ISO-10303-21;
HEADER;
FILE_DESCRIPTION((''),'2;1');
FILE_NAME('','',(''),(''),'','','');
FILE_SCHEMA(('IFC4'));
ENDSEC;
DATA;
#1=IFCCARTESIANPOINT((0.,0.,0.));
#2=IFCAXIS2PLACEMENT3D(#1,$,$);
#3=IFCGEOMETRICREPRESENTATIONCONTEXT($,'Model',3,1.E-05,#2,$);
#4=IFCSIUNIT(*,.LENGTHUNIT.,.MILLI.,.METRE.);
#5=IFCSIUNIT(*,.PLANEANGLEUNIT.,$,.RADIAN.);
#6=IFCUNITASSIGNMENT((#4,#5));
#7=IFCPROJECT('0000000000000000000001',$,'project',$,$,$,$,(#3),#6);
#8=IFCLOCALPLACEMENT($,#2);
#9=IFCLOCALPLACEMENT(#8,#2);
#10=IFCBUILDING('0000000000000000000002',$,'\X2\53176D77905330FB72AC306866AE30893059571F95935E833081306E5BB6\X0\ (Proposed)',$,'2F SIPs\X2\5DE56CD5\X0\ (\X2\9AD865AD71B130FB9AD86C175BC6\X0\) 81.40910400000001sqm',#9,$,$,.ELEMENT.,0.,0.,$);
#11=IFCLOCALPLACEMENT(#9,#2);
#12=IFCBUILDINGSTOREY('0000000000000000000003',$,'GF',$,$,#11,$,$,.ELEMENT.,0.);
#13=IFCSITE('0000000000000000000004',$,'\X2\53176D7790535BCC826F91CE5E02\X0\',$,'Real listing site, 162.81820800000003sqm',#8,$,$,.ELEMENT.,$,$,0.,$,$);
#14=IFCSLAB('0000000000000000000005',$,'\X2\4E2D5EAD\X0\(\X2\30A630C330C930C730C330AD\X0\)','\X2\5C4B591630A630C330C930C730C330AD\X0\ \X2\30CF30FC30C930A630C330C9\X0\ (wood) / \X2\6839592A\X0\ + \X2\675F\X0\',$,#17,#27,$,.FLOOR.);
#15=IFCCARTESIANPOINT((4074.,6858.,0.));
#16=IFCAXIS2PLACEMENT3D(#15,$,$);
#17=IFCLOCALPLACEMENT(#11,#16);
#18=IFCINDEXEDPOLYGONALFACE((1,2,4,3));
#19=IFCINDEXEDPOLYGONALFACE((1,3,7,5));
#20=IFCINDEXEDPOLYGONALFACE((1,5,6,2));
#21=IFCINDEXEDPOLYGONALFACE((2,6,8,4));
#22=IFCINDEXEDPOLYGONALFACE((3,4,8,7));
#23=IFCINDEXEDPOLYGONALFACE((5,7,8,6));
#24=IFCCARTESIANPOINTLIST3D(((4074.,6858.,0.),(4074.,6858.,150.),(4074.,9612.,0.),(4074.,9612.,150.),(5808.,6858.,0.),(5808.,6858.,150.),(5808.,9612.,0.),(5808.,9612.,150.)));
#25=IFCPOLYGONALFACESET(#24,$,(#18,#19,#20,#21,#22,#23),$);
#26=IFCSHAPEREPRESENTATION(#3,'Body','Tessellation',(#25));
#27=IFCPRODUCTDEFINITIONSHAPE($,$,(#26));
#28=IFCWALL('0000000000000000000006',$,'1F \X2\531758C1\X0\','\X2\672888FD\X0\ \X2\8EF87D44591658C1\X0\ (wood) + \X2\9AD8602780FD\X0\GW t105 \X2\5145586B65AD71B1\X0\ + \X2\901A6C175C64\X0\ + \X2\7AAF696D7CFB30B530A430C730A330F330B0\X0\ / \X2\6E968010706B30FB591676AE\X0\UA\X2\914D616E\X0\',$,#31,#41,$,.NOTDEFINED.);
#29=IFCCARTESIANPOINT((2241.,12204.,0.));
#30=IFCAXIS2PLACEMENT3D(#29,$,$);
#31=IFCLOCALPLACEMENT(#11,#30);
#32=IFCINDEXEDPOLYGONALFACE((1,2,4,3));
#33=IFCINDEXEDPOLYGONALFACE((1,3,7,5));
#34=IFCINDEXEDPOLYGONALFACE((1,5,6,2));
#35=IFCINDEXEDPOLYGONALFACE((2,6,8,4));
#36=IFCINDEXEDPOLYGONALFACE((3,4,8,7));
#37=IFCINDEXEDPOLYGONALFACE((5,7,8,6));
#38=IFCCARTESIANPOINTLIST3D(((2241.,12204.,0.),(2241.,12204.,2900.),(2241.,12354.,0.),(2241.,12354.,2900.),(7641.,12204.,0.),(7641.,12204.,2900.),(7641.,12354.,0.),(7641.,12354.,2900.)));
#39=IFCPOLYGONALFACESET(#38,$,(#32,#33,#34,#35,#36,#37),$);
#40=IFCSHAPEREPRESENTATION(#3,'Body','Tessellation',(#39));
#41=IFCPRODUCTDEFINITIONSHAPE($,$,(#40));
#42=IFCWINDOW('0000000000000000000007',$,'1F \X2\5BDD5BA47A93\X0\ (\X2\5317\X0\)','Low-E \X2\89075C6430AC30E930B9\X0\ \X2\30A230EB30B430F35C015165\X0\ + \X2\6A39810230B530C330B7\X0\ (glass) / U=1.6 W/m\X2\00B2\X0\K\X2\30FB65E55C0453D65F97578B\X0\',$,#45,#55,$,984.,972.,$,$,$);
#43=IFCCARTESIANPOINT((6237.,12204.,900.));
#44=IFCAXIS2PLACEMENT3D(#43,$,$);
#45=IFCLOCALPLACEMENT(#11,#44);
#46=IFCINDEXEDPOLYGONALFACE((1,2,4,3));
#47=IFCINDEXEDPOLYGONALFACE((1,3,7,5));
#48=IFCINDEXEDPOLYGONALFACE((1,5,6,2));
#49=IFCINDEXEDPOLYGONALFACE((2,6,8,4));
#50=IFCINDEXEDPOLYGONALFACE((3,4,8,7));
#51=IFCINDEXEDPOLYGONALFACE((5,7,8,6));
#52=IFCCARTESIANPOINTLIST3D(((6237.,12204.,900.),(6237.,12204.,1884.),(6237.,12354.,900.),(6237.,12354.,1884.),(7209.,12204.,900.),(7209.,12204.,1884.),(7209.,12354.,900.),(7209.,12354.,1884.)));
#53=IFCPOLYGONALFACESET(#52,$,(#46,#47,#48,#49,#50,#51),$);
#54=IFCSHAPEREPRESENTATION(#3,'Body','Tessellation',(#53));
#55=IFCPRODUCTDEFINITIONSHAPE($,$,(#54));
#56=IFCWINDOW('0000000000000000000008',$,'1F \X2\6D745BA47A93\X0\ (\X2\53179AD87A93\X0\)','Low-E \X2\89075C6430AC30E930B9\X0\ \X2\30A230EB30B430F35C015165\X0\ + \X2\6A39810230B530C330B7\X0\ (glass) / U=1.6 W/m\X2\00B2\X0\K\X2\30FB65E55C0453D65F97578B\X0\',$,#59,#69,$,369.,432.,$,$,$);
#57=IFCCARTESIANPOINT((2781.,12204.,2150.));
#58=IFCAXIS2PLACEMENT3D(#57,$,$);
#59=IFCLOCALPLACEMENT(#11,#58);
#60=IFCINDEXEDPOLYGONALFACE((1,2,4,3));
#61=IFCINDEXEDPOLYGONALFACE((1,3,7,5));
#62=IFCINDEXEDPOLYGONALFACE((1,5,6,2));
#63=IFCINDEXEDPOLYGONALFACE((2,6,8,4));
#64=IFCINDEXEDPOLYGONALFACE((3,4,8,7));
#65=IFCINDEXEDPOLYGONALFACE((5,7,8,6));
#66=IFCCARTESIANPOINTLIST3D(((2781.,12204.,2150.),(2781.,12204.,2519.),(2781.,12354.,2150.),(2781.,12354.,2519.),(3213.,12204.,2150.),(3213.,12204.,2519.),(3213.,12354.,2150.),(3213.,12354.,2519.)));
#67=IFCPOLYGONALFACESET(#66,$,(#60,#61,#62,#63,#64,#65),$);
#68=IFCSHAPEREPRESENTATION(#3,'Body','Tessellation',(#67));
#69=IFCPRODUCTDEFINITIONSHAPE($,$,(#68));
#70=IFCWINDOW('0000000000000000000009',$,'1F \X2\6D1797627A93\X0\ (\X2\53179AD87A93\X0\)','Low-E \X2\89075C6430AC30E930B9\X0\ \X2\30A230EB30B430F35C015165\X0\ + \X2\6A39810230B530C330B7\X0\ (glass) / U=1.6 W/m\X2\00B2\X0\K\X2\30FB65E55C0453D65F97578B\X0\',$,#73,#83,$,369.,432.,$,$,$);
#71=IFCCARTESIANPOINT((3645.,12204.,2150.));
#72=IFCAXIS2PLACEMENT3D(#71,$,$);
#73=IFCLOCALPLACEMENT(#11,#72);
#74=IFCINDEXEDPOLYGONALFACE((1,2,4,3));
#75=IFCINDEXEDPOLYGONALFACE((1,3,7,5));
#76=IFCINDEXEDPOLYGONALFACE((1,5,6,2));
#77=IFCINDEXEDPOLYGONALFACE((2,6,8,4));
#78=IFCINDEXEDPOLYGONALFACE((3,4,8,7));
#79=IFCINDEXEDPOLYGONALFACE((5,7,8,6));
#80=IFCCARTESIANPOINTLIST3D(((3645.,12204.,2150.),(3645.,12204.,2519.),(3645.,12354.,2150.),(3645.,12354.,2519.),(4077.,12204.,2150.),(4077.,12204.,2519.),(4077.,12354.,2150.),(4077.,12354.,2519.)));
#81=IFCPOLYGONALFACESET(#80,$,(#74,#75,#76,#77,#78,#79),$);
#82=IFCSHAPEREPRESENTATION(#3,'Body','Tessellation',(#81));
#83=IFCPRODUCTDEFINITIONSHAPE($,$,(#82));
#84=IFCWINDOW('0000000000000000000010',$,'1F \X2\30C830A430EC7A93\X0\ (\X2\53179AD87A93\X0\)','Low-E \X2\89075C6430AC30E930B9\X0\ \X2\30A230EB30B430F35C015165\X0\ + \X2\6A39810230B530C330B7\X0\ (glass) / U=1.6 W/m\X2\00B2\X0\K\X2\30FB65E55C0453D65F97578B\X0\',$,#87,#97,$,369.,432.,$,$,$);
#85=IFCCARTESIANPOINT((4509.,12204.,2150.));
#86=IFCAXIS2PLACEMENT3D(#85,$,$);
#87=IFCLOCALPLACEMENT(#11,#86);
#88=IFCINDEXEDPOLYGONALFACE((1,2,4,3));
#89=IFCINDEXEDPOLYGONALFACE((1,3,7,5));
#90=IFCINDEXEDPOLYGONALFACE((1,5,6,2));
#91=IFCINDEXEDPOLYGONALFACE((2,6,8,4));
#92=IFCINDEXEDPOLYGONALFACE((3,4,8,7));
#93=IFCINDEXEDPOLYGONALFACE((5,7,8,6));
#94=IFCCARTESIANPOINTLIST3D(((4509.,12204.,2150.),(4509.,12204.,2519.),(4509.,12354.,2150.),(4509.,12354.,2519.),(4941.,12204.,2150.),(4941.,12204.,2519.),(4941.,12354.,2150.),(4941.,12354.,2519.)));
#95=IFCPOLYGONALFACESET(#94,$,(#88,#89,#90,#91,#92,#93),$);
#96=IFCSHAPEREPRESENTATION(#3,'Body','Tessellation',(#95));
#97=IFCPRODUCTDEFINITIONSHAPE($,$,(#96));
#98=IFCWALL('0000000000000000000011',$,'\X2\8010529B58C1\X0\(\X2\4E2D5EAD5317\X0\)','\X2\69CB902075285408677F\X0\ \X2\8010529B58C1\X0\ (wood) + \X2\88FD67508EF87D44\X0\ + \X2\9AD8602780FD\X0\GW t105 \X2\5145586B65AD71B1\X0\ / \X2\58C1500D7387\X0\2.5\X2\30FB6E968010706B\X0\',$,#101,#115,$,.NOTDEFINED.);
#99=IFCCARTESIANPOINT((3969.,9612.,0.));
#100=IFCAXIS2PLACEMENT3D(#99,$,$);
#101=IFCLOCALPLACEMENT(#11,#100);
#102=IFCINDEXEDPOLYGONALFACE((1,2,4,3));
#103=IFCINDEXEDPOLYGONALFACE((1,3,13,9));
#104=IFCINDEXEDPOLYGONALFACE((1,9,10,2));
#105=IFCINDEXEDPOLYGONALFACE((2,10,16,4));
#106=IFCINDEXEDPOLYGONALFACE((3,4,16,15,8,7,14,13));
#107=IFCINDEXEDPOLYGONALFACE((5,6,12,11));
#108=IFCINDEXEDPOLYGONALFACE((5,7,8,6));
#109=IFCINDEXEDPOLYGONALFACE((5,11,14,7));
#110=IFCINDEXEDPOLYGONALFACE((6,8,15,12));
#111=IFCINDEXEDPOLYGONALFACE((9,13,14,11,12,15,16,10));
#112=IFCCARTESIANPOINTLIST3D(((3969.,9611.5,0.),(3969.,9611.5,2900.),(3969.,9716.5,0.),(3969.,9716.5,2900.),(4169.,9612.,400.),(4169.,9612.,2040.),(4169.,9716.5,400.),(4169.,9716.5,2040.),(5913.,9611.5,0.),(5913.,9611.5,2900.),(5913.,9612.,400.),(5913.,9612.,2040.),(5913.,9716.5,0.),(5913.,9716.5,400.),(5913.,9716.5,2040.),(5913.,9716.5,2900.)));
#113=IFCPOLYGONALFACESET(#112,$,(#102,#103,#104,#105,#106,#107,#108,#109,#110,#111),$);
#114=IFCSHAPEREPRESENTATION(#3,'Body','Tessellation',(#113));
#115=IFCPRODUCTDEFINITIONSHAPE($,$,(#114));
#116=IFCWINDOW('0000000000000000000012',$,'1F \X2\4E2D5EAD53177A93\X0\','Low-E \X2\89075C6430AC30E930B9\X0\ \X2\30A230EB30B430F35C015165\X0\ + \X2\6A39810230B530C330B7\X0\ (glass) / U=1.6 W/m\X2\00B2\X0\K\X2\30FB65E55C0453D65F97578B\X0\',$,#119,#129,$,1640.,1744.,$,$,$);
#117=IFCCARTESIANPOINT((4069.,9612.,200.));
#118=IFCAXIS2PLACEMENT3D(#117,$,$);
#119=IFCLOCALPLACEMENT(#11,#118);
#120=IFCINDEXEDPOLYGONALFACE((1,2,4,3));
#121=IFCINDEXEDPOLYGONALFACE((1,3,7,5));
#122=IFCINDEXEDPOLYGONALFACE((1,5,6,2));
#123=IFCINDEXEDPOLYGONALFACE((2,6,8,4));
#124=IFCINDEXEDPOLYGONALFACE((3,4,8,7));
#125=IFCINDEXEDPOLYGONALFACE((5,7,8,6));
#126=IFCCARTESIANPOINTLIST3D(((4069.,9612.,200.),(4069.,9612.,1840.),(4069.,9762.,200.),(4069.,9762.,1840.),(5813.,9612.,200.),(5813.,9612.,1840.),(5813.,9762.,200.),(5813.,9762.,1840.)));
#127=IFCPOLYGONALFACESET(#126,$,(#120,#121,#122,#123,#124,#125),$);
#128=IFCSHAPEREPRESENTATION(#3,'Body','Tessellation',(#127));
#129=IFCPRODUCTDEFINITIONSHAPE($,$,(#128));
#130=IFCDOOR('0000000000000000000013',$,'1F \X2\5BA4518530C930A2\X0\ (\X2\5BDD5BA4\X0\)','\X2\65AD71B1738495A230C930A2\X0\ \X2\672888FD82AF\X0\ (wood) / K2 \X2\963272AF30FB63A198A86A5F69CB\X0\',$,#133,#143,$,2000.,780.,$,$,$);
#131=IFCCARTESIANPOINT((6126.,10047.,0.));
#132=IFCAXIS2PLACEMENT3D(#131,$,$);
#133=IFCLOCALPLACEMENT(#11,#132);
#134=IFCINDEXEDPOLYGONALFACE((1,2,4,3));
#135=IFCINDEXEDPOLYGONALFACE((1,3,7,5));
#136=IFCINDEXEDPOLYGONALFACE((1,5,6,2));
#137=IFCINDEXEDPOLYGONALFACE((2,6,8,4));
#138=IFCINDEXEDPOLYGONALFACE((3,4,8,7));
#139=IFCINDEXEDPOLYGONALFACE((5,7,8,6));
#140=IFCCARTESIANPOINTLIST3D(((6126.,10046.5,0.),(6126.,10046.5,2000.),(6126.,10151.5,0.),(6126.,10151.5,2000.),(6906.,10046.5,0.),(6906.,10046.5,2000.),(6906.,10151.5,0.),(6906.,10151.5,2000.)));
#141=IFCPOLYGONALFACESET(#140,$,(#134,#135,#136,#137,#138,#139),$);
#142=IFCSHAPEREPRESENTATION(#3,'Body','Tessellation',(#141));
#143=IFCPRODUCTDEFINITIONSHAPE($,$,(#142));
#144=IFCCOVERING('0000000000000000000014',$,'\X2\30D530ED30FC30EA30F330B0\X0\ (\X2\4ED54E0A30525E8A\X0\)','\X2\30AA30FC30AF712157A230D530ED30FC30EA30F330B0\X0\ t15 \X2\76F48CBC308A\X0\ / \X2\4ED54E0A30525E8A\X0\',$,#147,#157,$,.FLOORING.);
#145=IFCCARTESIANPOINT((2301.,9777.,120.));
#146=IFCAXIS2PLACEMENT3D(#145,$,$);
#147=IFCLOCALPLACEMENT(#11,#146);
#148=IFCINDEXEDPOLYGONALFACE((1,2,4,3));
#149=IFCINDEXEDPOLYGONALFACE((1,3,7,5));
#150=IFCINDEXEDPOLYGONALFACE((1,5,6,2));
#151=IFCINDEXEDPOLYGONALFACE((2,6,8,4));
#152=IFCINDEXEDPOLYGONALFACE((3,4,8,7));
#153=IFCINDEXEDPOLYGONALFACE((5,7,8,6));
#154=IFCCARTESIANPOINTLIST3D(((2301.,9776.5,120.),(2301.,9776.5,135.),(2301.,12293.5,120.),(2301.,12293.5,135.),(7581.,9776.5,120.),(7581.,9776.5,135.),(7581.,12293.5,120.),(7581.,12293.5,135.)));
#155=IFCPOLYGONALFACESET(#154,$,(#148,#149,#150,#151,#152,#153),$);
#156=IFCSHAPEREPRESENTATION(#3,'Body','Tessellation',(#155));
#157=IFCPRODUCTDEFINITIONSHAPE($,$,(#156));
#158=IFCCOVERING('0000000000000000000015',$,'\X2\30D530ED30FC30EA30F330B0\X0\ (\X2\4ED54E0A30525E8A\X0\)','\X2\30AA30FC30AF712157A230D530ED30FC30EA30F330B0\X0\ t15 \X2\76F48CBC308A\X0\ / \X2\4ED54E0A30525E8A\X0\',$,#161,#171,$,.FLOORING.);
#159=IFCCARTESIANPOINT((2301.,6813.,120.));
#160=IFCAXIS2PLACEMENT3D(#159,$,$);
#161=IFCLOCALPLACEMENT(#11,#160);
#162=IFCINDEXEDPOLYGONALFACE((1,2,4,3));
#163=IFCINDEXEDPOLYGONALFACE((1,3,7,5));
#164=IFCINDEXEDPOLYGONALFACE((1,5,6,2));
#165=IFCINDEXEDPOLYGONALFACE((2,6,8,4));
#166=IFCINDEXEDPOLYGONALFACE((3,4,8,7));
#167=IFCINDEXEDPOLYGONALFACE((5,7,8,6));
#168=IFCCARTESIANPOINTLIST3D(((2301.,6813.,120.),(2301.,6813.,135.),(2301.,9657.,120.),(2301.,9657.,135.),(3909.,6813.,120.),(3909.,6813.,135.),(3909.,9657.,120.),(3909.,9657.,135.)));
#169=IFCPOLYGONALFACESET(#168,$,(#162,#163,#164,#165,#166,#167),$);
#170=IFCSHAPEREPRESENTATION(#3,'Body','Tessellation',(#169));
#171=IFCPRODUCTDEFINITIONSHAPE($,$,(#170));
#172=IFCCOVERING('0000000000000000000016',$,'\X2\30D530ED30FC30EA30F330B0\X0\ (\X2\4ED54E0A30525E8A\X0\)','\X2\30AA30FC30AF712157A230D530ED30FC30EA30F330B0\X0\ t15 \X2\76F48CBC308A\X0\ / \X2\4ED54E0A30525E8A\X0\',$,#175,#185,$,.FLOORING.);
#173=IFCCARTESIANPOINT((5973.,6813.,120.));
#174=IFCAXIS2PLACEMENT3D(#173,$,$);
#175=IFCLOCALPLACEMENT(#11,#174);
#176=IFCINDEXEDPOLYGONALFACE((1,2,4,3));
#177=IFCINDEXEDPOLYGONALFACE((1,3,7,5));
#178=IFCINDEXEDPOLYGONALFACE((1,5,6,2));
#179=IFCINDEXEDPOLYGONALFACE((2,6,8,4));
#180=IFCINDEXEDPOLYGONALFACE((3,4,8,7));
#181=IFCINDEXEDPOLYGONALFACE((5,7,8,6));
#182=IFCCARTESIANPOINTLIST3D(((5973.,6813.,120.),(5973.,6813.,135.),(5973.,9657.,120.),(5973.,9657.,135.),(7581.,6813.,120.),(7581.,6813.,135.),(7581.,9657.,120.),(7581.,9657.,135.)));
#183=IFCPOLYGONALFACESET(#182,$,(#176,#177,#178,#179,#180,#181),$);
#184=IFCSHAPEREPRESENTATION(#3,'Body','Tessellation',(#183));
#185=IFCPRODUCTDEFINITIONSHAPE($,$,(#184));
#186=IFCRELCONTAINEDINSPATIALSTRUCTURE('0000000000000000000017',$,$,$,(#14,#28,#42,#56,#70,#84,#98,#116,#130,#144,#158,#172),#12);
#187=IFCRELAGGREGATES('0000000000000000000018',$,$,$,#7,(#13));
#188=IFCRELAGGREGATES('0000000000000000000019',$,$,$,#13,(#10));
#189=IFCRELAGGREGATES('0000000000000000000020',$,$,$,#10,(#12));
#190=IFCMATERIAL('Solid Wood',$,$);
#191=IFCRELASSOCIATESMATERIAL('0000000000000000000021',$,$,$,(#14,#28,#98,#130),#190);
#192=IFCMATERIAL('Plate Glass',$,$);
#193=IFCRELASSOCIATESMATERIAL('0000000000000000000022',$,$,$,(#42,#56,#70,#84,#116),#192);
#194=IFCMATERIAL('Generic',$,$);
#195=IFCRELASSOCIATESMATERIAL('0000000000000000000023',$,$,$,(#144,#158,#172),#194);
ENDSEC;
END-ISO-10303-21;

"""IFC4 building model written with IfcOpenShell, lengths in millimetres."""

from ifc_helpers import new_model, si_unit, frame, frame_2d, origin, place, context, project, spatial, rectangle, extrude, material, element, fill, save


model = new_model("IFC4")

# Units and contexts
model_context = context("Model", 3, precision=1e-05, world=origin())
ifc_project = project(units=[si_unit("LENGTHUNIT", "METRE", prefix="MILLI"), si_unit("PLANEANGLEUNIT", "RADIAN")], contexts=[model_context])

# Site, building, storey
site_placement = place(None, origin())
site = spatial("IfcSite", under=ifc_project, at=site_placement, Name="北海道富良野市", ObjectType="Real listing site, 162.81820800000003sqm", CompositionType="ELEMENT", RefElevation=0.0)
building_placement = place(site_placement, origin())
building = spatial("IfcBuilding", under=site, at=building_placement, Name="北海道・犬と暮らす土間広めの家 (Proposed)", ObjectType="2F SIPs工法 (高断熱・高気密) 81.40910400000001sqm", CompositionType="ELEMENT", ElevationOfRefHeight=0.0, ElevationOfTerrain=0.0)
storey_placement = place(building_placement, origin())
storey = spatial("IfcBuildingStorey", under=building, at=storey_placement, Name="GF", CompositionType="ELEMENT", Elevation=0.0)

# Slab
ifc_material_1 = material(Name="Solid Wood")
slab_1_placement = place(storey_placement, frame((4074.0, 6858.0, 0.0)))
element("IfcSlab", 1, at=slab_1_placement, inside=storey, material=ifc_material_1, Name="中庭(ウッドデッキ)", Description="屋外ウッドデッキ ハードウッド (wood) / 根太 + 束", PredefinedType="FLOOR", context=model_context, shape_type="SweptSolid", body=[
    extrude(rectangle(XDim=1734.0, YDim=2754.0, at=frame_2d((867.0, 1377.0))), frame((4074.0, 6858.0, 0.0)), (0.0, 0.0, 1.0), 150.0),
])

# Wall, openings, windows
wall_1_placement = place(storey_placement, frame((2241.0, 12204.0, 0.0)))
wall_1 = element("IfcWall", 2, at=wall_1_placement, inside=storey, material=ifc_material_1, Name="1F 北壁", Description="木製 軸組外壁 (wood) + 高性能GW t105 充填断熱 + 通気層 + 窯業系サイディング / 準耐火・外皮UA配慮", PredefinedType="NOTDEFINED", context=model_context, shape_type="SweptSolid", body=[
    extrude(rectangle(XDim=5400.0, YDim=150.0, at=frame_2d((2700.0, 75.0))), frame((2241.0, 12204.0, 0.0)), (0.0, 0.0, 1.0), 2900.0),
])
opening_1_placement = place(storey_placement, frame((6237.0, 12204.0, 900.0)))
opening_1 = element("IfcOpeningElement", 3, at=opening_1_placement, cuts=wall_1, PredefinedType="NOTDEFINED", context=model_context, shape_type="SweptSolid", body=[
    extrude(rectangle(XDim=972.0, YDim=150.0, at=frame_2d((486.0, 75.0))), frame((6237.0, 12204.0, 900.0)), (0.0, 0.0, 1.0), 984.0),
])
opening_2_placement = place(storey_placement, frame((2781.0, 12204.0, 2150.0)))
opening_2 = element("IfcOpeningElement", 4, at=opening_2_placement, cuts=wall_1, PredefinedType="NOTDEFINED", context=model_context, shape_type="SweptSolid", body=[
    extrude(rectangle(XDim=432.0, YDim=150.0, at=frame_2d((216.0, 75.0))), frame((2781.0, 12204.0, 2150.0)), (0.0, 0.0, 1.0), 369.0),
])
opening_3_placement = place(storey_placement, frame((3645.0, 12204.0, 2150.0)))
opening_3 = element("IfcOpeningElement", 5, at=opening_3_placement, cuts=wall_1, PredefinedType="NOTDEFINED", context=model_context, shape_type="SweptSolid", body=[
    extrude(rectangle(XDim=432.0, YDim=150.0, at=frame_2d((216.0, 75.0))), frame((3645.0, 12204.0, 2150.0)), (0.0, 0.0, 1.0), 369.0),
])
opening_4_placement = place(storey_placement, frame((4509.0, 12204.0, 2150.0)))
opening_4 = element("IfcOpeningElement", 6, at=opening_4_placement, cuts=wall_1, PredefinedType="NOTDEFINED", context=model_context, shape_type="SweptSolid", body=[
    extrude(rectangle(XDim=432.0, YDim=150.0, at=frame_2d((216.0, 75.0))), frame((4509.0, 12204.0, 2150.0)), (0.0, 0.0, 1.0), 369.0),
])
ifc_material_2 = material(Name="Plate Glass")
window_1_placement = place(storey_placement, frame((6237.0, 12204.0, 900.0)))
window_1 = element("IfcWindow", 7, at=window_1_placement, inside=storey, material=ifc_material_2, Name="1F 寝室窓 (北)", Description="Low-E 複層ガラス アルゴン封入 + 樹脂サッシ (glass) / U=1.6 W/m²K・日射取得型", OverallHeight=984.0, OverallWidth=972.0, context=model_context, shape_type="SweptSolid", body=[
    extrude(rectangle(XDim=972.0, YDim=150.0, at=frame_2d((486.0, 75.0))), frame((6237.0, 12204.0, 900.0)), (0.0, 0.0, 1.0), 984.0),
])
fill(opening_1, window_1)
window_2_placement = place(storey_placement, frame((2781.0, 12204.0, 2150.0)))
window_2 = element("IfcWindow", 8, at=window_2_placement, inside=storey, material=ifc_material_2, Name="1F 浴室窓 (北高窓)", Description="Low-E 複層ガラス アルゴン封入 + 樹脂サッシ (glass) / U=1.6 W/m²K・日射取得型", OverallHeight=369.0, OverallWidth=432.0, context=model_context, shape_type="SweptSolid", body=[
    extrude(rectangle(XDim=432.0, YDim=150.0, at=frame_2d((216.0, 75.0))), frame((2781.0, 12204.0, 2150.0)), (0.0, 0.0, 1.0), 369.0),
])
fill(opening_2, window_2)
window_3_placement = place(storey_placement, frame((3645.0, 12204.0, 2150.0)))
window_3 = element("IfcWindow", 9, at=window_3_placement, inside=storey, material=ifc_material_2, Name="1F 洗面窓 (北高窓)", Description="Low-E 複層ガラス アルゴン封入 + 樹脂サッシ (glass) / U=1.6 W/m²K・日射取得型", OverallHeight=369.0, OverallWidth=432.0, context=model_context, shape_type="SweptSolid", body=[
    extrude(rectangle(XDim=432.0, YDim=150.0, at=frame_2d((216.0, 75.0))), frame((3645.0, 12204.0, 2150.0)), (0.0, 0.0, 1.0), 369.0),
])
fill(opening_3, window_3)
window_4_placement = place(storey_placement, frame((4509.0, 12204.0, 2150.0)))
window_4 = element("IfcWindow", 10, at=window_4_placement, inside=storey, material=ifc_material_2, Name="1F トイレ窓 (北高窓)", Description="Low-E 複層ガラス アルゴン封入 + 樹脂サッシ (glass) / U=1.6 W/m²K・日射取得型", OverallHeight=369.0, OverallWidth=432.0, context=model_context, shape_type="SweptSolid", body=[
    extrude(rectangle(XDim=432.0, YDim=150.0, at=frame_2d((216.0, 75.0))), frame((4509.0, 12204.0, 2150.0)), (0.0, 0.0, 1.0), 369.0),
])
fill(opening_4, window_4)

# Wall, opening, window
wall_2_placement = place(storey_placement, frame((3969.0, 9612.0, 0.0)))
wall_2 = element("IfcWall", 11, at=wall_2_placement, inside=storey, material=ifc_material_1, Name="耐力壁(中庭北)", Description="構造用合板 耐力壁 (wood) + 製材軸組 + 高性能GW t105 充填断熱 / 壁倍率2.5・準耐火", PredefinedType="NOTDEFINED", context=model_context, shape_type="SweptSolid", body=[
    extrude(rectangle(XDim=1944.0, YDim=105.0, at=frame_2d((972.0, 52.0))), frame((3969.0, 9612.0, 0.0)), (0.0, 0.0, 1.0), 2900.0),
])
opening_5_placement = place(storey_placement, frame((4069.0, 9612.0, 200.0)))
opening_5 = element("IfcOpeningElement", 12, at=opening_5_placement, cuts=wall_2, PredefinedType="NOTDEFINED", context=model_context, shape_type="SweptSolid", body=[
    extrude(rectangle(XDim=1744.0, YDim=150.0, at=frame_2d((872.0, 75.0))), frame((4069.0, 9612.0, 200.0)), (0.0, 0.0, 1.0), 1640.0),
])
window_5_placement = place(storey_placement, frame((4069.0, 9612.0, 200.0)))
window_5 = element("IfcWindow", 13, at=window_5_placement, inside=storey, material=ifc_material_2, Name="1F 中庭北窓", Description="Low-E 複層ガラス アルゴン封入 + 樹脂サッシ (glass) / U=1.6 W/m²K・日射取得型", OverallHeight=1640.0, OverallWidth=1744.0, context=model_context, shape_type="SweptSolid", body=[
    extrude(rectangle(XDim=1744.0, YDim=150.0, at=frame_2d((872.0, 75.0))), frame((4069.0, 9612.0, 200.0)), (0.0, 0.0, 1.0), 1640.0),
])
fill(opening_5, window_5)

# Door
door_1_placement = place(storey_placement, frame((6126.0, 10047.0, 0.0)))
element("IfcDoor", 14, at=door_1_placement, inside=storey, material=ifc_material_1, Name="1F 室内ドア (寝室)", Description="断熱玄関ドア 木製芯 (wood) / K2 防犯・採風機構", OverallHeight=2000.0, OverallWidth=780.0, context=model_context, shape_type="SweptSolid", body=[
    extrude(rectangle(XDim=780.0, YDim=105.0, at=frame_2d((390.0, 52.0))), frame((6126.0, 10047.0, 0.0)), (0.0, 0.0, 1.0), 2000.0),
])

# Coverings
ifc_material_3 = material(Name="Generic")
covering_1_placement = place(storey_placement, frame((2301.0, 9777.0, 120.0)))
element("IfcCovering", 15, at=covering_1_placement, inside=storey, material=ifc_material_3, Name="フローリング (仕上げ床)", Description="オーク無垢フローリング t15 直貼り / 仕上げ床", PredefinedType="FLOORING", context=model_context, shape_type="SweptSolid", body=[
    extrude(rectangle(XDim=5280.0, YDim=2517.0, at=frame_2d((2640.0, 1258.0))), frame((2301.0, 9777.0, 120.0)), (0.0, 0.0, 1.0), 15.0),
])
covering_2_placement = place(storey_placement, frame((2301.0, 6813.0, 120.0)))
element("IfcCovering", 16, at=covering_2_placement, inside=storey, material=ifc_material_3, Name="フローリング (仕上げ床)", Description="オーク無垢フローリング t15 直貼り / 仕上げ床", PredefinedType="FLOORING", context=model_context, shape_type="SweptSolid", body=[
    extrude(rectangle(XDim=1608.0, YDim=2844.0, at=frame_2d((804.0, 1422.0))), frame((2301.0, 6813.0, 120.0)), (0.0, 0.0, 1.0), 15.0),
])
covering_3_placement = place(storey_placement, frame((5973.0, 6813.0, 120.0)))
element("IfcCovering", 17, at=covering_3_placement, inside=storey, material=ifc_material_3, Name="フローリング (仕上げ床)", Description="オーク無垢フローリング t15 直貼り / 仕上げ床", PredefinedType="FLOORING", context=model_context, shape_type="SweptSolid", body=[
    extrude(rectangle(XDim=1608.0, YDim=2844.0, at=frame_2d((804.0, 1422.0))), frame((5973.0, 6813.0, 120.0)), (0.0, 0.0, 1.0), 15.0),
])

save(model, "model.ifc")
